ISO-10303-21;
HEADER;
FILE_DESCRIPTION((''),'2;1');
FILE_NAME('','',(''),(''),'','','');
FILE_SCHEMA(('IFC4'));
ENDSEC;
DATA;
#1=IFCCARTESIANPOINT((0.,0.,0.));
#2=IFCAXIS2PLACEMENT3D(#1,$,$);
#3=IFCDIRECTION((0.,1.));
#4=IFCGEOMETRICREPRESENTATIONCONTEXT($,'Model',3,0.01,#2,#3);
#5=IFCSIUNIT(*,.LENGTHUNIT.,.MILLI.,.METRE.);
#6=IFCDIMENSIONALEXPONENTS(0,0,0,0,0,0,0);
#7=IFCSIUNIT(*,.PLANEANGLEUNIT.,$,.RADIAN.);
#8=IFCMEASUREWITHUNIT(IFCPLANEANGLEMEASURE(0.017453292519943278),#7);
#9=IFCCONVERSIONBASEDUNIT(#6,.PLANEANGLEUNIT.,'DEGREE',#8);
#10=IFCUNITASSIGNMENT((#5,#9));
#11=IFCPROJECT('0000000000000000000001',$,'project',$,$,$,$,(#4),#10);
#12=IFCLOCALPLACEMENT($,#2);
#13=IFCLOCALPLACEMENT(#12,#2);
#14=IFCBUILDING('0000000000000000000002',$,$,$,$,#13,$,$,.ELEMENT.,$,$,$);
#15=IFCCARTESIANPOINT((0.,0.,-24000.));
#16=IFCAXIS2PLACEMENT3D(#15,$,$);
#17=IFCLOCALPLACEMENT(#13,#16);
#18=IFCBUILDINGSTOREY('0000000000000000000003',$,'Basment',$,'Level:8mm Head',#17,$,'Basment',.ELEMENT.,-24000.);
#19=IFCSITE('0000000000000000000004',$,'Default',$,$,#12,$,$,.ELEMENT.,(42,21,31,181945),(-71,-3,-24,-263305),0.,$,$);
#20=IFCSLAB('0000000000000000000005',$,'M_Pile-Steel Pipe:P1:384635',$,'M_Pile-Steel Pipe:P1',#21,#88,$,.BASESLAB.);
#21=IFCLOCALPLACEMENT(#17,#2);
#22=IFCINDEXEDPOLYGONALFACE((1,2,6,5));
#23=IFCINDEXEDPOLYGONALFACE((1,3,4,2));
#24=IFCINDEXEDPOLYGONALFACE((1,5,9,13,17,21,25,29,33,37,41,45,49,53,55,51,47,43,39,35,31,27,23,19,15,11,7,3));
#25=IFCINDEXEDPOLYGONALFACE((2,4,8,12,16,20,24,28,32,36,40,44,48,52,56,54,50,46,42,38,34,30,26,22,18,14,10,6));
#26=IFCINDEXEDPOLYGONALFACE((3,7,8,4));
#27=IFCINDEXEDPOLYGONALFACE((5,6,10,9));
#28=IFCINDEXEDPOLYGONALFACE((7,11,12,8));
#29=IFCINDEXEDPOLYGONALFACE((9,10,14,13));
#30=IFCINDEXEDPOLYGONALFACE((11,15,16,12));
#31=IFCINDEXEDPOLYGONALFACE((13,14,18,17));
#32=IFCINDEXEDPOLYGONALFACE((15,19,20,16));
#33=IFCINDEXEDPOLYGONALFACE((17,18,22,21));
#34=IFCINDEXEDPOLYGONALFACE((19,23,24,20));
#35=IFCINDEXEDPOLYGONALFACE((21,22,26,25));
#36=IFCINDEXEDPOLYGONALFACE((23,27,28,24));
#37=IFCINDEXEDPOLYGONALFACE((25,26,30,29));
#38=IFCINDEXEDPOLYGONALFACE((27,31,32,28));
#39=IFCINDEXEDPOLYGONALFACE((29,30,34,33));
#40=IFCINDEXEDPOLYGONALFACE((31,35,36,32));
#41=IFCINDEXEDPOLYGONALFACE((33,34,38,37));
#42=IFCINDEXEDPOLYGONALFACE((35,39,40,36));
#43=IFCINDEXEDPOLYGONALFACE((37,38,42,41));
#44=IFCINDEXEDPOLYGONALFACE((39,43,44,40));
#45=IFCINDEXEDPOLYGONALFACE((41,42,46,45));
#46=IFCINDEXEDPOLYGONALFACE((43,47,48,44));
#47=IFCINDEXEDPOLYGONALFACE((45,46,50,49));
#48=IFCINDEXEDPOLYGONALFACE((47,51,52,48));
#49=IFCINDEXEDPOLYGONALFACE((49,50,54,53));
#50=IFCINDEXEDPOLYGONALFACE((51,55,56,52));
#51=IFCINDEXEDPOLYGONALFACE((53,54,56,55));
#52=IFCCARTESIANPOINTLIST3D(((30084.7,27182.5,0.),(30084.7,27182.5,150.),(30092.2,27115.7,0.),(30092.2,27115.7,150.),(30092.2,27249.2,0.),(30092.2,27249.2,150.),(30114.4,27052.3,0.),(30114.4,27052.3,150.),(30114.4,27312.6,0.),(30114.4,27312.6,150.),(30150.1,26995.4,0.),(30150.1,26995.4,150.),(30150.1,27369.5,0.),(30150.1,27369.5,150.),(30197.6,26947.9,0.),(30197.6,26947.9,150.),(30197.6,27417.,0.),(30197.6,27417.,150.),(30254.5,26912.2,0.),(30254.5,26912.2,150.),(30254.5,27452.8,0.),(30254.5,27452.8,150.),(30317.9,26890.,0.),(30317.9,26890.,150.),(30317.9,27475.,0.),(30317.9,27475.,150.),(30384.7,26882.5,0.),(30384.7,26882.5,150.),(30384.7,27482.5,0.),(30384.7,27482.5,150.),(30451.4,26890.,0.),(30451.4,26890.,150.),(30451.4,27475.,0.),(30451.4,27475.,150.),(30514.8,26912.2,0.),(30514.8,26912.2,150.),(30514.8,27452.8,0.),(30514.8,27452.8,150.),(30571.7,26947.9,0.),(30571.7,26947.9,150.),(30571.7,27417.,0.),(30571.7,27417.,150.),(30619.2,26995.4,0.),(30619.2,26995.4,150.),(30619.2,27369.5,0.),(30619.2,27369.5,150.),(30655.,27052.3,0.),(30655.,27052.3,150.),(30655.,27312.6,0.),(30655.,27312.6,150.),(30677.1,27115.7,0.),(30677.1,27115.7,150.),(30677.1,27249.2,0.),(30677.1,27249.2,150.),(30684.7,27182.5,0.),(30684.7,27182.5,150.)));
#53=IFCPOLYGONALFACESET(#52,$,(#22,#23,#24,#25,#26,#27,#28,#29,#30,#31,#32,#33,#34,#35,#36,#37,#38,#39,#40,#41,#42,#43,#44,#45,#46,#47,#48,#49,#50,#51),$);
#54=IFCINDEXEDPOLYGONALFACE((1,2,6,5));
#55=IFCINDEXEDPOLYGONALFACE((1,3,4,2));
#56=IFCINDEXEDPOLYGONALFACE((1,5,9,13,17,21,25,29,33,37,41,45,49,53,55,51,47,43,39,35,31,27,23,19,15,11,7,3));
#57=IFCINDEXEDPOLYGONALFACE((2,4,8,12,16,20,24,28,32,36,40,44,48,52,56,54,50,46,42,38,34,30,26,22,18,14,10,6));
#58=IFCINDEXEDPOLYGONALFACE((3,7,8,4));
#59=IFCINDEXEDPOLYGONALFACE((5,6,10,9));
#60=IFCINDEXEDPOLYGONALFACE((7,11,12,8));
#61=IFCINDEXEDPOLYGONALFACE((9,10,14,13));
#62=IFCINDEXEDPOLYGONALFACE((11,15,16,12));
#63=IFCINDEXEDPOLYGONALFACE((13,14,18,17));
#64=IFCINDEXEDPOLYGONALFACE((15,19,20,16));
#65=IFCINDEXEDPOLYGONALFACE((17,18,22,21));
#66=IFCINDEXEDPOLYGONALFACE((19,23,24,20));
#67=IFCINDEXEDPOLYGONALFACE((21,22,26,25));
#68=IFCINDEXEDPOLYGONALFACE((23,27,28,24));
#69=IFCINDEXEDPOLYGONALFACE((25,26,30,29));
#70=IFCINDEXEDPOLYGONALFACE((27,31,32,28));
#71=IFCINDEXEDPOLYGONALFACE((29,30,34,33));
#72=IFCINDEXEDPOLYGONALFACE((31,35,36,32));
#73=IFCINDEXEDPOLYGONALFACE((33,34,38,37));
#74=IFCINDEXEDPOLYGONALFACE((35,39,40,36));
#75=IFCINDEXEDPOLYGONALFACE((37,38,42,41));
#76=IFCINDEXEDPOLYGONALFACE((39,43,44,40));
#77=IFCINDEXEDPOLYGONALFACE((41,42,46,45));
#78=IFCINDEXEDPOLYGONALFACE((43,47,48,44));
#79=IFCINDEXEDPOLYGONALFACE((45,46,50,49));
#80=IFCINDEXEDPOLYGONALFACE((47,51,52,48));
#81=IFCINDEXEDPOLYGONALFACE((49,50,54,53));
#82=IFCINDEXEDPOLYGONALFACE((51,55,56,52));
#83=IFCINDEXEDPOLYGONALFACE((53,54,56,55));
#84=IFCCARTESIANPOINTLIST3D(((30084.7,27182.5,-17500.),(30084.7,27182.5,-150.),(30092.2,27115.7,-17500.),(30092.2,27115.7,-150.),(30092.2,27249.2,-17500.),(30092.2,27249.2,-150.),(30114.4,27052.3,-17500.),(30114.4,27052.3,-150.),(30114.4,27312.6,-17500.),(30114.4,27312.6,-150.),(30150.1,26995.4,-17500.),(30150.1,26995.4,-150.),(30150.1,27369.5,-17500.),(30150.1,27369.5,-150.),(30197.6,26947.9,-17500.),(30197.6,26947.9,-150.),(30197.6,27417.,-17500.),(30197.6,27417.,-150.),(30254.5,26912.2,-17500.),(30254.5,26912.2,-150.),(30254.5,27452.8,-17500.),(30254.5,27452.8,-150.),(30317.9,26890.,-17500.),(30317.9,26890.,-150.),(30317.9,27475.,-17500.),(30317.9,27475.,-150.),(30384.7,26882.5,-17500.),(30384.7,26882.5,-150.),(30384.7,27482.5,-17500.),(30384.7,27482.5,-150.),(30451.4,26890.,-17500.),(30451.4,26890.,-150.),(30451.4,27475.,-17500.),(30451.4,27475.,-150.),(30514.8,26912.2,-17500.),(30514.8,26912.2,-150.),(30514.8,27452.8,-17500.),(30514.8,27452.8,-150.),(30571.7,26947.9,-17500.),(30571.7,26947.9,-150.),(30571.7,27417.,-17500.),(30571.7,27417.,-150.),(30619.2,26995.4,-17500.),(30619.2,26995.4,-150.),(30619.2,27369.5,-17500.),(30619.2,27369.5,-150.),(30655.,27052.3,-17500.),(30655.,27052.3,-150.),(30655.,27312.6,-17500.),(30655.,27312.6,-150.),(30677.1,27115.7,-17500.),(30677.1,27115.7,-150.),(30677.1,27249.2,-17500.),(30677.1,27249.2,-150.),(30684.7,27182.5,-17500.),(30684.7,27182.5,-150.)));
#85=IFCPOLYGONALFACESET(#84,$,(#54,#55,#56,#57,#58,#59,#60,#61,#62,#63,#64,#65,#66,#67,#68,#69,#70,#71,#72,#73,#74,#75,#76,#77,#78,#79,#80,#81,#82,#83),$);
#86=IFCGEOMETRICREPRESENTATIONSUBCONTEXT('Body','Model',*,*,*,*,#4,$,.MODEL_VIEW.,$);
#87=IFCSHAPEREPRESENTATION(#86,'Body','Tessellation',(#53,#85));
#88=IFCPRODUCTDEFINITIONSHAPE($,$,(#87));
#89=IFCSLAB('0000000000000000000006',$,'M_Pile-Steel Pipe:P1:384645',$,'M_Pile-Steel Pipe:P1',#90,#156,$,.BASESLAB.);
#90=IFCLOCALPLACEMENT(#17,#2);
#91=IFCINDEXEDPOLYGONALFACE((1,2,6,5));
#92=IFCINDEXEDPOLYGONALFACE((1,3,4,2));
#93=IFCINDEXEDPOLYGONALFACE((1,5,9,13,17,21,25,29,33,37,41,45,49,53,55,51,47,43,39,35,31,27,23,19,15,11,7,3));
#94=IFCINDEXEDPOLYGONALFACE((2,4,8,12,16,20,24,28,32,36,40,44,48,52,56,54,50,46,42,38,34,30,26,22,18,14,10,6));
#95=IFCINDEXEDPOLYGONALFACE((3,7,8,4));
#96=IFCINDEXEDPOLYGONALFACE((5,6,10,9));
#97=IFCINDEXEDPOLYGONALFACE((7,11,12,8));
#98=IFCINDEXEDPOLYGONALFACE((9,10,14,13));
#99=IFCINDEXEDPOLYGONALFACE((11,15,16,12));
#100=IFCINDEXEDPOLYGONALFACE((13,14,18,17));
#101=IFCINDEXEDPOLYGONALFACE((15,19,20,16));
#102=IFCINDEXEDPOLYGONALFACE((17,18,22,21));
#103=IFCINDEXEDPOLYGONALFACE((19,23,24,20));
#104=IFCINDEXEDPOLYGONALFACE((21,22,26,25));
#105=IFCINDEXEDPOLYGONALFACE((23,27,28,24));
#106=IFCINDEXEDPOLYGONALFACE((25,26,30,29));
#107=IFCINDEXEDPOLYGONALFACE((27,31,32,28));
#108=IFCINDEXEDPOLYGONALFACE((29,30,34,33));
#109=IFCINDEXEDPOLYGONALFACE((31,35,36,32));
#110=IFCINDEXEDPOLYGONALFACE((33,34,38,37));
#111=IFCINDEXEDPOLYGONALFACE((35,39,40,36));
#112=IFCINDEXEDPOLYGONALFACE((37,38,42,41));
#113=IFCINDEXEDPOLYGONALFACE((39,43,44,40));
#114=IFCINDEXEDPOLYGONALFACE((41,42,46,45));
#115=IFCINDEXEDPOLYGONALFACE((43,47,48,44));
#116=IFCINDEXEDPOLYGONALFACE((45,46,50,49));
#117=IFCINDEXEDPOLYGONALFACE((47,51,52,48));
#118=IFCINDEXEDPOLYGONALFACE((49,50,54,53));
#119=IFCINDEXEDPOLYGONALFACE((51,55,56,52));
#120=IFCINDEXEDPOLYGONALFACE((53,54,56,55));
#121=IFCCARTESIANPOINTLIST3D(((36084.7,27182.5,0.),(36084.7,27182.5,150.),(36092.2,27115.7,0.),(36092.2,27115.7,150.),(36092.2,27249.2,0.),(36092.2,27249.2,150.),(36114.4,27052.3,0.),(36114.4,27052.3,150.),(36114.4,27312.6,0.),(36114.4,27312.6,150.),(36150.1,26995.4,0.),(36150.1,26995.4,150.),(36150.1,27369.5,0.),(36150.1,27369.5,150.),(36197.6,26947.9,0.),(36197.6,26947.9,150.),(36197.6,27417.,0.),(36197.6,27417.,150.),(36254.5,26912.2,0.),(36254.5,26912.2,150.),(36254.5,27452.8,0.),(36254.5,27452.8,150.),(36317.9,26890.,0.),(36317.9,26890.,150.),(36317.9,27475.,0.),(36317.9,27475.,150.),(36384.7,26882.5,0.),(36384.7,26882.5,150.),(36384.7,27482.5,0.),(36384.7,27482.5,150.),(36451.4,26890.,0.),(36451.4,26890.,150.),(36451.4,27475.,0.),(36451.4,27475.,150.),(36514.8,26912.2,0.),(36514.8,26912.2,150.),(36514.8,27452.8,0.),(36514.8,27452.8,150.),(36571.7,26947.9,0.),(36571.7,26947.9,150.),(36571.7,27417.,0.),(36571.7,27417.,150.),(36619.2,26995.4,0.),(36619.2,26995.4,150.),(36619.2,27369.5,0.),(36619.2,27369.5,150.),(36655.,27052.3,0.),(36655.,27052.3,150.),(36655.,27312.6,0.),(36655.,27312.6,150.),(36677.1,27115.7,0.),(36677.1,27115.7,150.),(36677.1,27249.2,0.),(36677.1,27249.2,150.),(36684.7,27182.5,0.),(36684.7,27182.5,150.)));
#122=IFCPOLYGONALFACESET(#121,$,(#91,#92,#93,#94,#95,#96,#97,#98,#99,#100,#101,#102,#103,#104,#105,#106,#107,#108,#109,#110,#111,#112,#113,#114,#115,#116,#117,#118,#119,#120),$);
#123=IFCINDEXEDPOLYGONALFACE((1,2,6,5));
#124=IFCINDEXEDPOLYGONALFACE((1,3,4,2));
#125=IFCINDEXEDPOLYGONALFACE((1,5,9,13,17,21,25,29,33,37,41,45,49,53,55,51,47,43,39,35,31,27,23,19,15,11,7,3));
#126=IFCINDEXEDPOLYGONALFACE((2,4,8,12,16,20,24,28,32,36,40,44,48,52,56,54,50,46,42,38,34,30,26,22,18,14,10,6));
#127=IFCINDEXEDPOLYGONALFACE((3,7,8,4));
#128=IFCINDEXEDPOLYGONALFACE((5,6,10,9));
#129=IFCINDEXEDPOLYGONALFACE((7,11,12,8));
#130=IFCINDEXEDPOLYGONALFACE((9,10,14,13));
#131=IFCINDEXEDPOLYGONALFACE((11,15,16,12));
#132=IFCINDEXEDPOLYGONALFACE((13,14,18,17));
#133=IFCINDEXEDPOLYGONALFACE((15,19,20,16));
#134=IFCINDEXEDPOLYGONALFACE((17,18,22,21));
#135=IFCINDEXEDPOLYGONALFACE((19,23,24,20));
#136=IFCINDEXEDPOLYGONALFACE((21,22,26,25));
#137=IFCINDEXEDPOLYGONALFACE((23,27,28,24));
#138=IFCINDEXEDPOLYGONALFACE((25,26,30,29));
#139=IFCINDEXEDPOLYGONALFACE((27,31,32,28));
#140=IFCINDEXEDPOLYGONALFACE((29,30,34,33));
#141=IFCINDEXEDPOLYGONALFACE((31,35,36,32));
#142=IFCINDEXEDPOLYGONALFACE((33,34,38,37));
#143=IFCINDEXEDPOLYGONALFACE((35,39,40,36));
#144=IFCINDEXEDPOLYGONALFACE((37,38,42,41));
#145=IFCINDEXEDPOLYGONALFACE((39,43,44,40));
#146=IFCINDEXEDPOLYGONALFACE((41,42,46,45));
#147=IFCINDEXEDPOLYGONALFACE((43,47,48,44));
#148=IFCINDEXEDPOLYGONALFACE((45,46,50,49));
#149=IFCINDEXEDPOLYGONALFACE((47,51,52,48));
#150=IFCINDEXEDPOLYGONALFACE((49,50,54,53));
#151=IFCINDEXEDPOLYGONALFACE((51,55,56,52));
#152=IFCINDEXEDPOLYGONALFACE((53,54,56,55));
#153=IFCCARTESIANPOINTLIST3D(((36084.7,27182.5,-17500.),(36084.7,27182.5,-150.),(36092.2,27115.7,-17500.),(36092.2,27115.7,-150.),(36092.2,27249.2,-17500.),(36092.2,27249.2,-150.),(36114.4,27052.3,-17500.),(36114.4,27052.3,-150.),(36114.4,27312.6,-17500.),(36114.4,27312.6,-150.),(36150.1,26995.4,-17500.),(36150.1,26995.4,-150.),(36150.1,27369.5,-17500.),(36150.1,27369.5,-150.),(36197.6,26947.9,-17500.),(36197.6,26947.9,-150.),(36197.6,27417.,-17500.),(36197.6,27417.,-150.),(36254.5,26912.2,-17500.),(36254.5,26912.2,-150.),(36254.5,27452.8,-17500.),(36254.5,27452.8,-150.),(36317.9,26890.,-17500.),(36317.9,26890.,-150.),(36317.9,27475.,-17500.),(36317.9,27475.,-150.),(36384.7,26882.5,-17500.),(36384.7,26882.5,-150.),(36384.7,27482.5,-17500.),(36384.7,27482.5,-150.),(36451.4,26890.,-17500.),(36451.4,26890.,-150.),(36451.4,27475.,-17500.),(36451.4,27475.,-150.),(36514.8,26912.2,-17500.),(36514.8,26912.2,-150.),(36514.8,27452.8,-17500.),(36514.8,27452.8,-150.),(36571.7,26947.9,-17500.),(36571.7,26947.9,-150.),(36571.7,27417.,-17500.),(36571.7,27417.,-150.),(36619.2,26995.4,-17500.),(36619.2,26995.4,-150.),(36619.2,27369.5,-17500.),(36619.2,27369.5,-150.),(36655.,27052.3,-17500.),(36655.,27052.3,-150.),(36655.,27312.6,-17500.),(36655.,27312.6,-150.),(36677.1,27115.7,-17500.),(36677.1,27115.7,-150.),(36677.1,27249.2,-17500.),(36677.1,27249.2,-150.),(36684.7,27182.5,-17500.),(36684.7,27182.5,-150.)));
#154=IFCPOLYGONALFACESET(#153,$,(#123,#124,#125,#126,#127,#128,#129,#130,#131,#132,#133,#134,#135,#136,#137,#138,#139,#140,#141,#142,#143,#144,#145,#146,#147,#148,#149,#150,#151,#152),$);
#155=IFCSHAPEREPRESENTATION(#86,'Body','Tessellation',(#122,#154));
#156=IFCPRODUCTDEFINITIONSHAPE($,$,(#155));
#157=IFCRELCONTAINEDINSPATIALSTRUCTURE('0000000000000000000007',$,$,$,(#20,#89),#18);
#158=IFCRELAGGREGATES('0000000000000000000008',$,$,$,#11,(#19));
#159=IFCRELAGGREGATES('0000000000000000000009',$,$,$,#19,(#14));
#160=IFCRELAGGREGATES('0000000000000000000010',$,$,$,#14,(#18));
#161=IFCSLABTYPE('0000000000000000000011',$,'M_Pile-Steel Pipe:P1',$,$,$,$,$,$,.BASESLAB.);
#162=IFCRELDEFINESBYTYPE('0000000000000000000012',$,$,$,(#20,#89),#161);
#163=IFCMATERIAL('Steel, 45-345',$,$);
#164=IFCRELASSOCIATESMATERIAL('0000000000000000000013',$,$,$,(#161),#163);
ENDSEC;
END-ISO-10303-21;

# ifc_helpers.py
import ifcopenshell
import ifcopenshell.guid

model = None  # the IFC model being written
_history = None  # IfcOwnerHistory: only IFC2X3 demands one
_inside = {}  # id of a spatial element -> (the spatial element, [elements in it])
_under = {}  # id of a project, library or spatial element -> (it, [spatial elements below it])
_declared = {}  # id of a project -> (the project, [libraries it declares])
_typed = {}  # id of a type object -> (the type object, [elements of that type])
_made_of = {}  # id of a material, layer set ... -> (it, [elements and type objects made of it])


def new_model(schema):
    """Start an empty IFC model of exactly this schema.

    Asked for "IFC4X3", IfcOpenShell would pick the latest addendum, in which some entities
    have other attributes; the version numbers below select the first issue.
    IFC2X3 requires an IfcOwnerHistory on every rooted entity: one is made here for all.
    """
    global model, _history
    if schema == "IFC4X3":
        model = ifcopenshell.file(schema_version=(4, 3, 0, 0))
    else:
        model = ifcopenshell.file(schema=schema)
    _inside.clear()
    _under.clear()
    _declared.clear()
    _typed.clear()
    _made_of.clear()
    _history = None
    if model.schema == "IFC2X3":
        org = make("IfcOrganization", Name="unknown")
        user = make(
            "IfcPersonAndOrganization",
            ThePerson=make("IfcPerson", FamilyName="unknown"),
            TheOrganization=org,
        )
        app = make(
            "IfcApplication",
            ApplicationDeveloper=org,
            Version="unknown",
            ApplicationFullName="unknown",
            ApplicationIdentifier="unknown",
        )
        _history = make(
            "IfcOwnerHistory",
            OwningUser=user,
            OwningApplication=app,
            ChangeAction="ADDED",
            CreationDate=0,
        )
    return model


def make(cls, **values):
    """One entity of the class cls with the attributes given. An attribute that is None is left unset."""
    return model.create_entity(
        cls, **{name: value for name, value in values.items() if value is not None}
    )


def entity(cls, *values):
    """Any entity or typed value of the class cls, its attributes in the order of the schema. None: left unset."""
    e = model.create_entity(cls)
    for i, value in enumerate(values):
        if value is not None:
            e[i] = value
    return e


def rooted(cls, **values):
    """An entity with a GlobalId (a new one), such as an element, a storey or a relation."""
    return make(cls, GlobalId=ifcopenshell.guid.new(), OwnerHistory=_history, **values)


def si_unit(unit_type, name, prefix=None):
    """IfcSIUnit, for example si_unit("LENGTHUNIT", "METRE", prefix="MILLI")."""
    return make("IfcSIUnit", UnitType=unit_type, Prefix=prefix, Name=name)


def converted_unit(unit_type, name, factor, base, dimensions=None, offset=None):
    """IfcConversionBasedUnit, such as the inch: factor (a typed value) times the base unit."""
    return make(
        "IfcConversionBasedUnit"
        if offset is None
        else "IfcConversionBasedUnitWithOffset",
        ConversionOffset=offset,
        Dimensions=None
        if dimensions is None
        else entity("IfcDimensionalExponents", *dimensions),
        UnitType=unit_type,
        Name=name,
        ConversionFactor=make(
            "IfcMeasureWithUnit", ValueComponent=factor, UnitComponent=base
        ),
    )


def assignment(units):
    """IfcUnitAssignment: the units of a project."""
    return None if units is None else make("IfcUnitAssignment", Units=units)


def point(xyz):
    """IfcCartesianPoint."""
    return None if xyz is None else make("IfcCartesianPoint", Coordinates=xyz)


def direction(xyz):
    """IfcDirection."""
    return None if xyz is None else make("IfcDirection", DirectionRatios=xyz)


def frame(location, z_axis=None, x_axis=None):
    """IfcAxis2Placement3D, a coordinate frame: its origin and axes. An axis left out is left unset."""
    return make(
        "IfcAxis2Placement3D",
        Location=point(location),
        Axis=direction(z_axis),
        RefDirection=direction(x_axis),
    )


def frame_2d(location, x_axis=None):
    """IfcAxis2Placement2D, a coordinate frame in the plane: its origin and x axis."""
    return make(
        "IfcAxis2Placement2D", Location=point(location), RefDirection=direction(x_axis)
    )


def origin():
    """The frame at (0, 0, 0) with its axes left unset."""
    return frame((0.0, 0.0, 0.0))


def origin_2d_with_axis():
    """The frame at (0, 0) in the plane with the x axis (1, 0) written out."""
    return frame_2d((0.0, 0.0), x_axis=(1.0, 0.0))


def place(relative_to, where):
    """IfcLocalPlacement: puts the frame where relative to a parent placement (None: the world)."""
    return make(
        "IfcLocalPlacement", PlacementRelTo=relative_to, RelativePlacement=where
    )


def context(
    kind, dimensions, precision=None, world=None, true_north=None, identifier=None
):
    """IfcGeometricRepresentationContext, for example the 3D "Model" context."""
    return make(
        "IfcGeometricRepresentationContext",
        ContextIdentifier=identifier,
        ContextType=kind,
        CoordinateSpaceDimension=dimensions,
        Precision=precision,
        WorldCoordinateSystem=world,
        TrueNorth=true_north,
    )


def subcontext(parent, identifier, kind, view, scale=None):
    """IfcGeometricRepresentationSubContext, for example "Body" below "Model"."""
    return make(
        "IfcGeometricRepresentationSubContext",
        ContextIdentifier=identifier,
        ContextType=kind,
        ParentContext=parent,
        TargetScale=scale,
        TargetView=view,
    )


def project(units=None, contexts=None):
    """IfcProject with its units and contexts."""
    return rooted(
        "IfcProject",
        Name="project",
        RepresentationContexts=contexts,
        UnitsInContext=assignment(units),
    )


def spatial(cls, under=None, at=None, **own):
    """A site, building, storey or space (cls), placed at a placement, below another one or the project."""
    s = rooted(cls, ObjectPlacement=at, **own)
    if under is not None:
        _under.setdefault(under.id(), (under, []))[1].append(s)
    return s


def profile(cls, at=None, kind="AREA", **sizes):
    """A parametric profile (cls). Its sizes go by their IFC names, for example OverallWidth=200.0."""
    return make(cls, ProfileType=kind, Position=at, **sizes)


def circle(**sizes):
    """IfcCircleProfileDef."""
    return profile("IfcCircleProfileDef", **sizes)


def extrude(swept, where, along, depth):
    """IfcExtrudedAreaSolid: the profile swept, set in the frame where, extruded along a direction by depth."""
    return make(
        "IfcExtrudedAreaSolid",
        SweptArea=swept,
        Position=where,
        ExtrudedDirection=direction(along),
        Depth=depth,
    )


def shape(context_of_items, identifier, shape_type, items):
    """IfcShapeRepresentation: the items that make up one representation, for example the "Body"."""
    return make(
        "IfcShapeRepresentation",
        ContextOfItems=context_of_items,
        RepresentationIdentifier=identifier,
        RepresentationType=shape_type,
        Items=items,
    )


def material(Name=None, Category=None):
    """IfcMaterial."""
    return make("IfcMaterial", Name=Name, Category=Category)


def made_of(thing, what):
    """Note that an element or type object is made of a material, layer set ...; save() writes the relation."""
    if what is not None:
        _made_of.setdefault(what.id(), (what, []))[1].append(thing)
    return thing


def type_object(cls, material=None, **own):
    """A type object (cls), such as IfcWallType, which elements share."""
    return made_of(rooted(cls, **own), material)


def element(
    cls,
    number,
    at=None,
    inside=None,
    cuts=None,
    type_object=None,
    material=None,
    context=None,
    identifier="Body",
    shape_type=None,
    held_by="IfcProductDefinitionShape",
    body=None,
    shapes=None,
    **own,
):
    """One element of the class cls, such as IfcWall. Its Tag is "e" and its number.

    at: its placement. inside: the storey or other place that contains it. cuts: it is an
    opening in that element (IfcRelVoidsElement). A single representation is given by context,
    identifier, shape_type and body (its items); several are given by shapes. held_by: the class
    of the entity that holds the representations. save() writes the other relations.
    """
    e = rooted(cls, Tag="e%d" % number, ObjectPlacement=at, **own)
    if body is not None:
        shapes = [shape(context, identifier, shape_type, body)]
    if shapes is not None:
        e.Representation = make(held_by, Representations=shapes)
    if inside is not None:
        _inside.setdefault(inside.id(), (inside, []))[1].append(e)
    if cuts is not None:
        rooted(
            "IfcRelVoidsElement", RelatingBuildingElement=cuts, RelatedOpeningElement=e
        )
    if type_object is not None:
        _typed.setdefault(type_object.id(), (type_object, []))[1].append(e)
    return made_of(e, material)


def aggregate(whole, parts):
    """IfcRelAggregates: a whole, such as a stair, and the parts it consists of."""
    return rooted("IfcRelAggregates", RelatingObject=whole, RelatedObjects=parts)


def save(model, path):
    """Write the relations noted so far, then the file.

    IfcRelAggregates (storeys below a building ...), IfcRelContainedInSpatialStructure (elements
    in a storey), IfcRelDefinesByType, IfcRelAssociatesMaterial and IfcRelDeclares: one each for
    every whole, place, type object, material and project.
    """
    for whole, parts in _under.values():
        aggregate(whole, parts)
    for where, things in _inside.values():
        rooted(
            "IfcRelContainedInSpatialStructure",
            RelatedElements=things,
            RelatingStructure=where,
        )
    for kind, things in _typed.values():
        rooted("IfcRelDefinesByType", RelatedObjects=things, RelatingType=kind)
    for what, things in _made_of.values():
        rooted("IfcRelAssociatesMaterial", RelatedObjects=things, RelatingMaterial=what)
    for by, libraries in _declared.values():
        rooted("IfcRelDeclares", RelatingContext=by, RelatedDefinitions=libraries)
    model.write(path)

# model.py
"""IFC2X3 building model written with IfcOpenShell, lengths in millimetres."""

from ifc_helpers import new_model, entity, si_unit, converted_unit, direction, frame, origin, origin_2d_with_axis, place, context, subcontext, project, spatial, circle, extrude, material, type_object, element, save


model = new_model("IFC2X3")

# Units and contexts
model_context = context("Model", 3, precision=0.01, world=origin(), true_north=direction((0.0, 1.0)))
body_context = subcontext(model_context, "Body", "Model", "MODEL_VIEW")
ifc_project = project(units=[si_unit("LENGTHUNIT", "METRE", prefix="MILLI"), converted_unit("PLANEANGLEUNIT", "DEGREE", entity("IfcPlaneAngleMeasure", 0.017453292519943278), si_unit("PLANEANGLEUNIT", "RADIAN"), dimensions=[0, 0, 0, 0, 0, 0, 0])], contexts=[model_context])

# Site, building, storey
site_placement = place(None, origin())
site = spatial("IfcSite", under=ifc_project, at=site_placement, Name="Default", CompositionType="ELEMENT", RefLatitude=(42, 21, 31, 181945), RefLongitude=(-71, -3, -24, -263305), RefElevation=0.0)
building_placement = place(site_placement, origin())
building = spatial("IfcBuilding", under=site, at=building_placement, CompositionType="ELEMENT")
storey_placement = place(building_placement, frame((0.0, 0.0, -24000.0)))
storey = spatial("IfcBuildingStorey", under=building, at=storey_placement, Name="Basment", ObjectType="Level:8mm Head", LongName="Basment", CompositionType="ELEMENT", Elevation=-24000.0)

# Slabs
ifc_material_1 = material(Name="Steel, 45-345")
slab_type_1 = type_object("IfcSlabType", Name="M_Pile-Steel Pipe:P1", PredefinedType="BASESLAB", material=ifc_material_1)
slab_1_placement = place(storey_placement, origin())
element("IfcSlab", 1, at=slab_1_placement, inside=storey, type_object=slab_type_1, Name="M_Pile-Steel Pipe:P1:384635", ObjectType="M_Pile-Steel Pipe:P1", PredefinedType="BASESLAB", context=body_context, shape_type="SweptSolid", body=[
    extrude(circle(Radius=300.0, at=origin_2d_with_axis()), frame((30384.7, 27182.5, 0.0), z_axis=(0.0, 0.0, 1.0), x_axis=(0.0, 1.0, 0.0)), (0.0, 0.0, 1.0), 150.0),
    extrude(circle(Radius=300.0, at=origin_2d_with_axis()), frame((30384.7, 27182.5, -17500.0), z_axis=(0.0, 0.0, 1.0), x_axis=(0.0, 1.0, 0.0)), (0.0, 0.0, 1.0), 17350.0),
])
slab_2_placement = place(storey_placement, origin())
element("IfcSlab", 2, at=slab_2_placement, inside=storey, type_object=slab_type_1, Name="M_Pile-Steel Pipe:P1:384645", ObjectType="M_Pile-Steel Pipe:P1", PredefinedType="BASESLAB", context=body_context, shape_type="SweptSolid", body=[
    extrude(circle(Radius=300.0, at=origin_2d_with_axis()), frame((36384.7, 27182.5, 0.0), z_axis=(0.0, 0.0, 1.0), x_axis=(0.0, 1.0, 0.0)), (0.0, 0.0, 1.0), 150.0),
    extrude(circle(Radius=300.0, at=origin_2d_with_axis()), frame((36384.7, 27182.5, -17500.0), z_axis=(0.0, 0.0, 1.0), x_axis=(0.0, 1.0, 0.0)), (0.0, 0.0, 1.0), 17350.0),
])

save(model, "model.ifc")
